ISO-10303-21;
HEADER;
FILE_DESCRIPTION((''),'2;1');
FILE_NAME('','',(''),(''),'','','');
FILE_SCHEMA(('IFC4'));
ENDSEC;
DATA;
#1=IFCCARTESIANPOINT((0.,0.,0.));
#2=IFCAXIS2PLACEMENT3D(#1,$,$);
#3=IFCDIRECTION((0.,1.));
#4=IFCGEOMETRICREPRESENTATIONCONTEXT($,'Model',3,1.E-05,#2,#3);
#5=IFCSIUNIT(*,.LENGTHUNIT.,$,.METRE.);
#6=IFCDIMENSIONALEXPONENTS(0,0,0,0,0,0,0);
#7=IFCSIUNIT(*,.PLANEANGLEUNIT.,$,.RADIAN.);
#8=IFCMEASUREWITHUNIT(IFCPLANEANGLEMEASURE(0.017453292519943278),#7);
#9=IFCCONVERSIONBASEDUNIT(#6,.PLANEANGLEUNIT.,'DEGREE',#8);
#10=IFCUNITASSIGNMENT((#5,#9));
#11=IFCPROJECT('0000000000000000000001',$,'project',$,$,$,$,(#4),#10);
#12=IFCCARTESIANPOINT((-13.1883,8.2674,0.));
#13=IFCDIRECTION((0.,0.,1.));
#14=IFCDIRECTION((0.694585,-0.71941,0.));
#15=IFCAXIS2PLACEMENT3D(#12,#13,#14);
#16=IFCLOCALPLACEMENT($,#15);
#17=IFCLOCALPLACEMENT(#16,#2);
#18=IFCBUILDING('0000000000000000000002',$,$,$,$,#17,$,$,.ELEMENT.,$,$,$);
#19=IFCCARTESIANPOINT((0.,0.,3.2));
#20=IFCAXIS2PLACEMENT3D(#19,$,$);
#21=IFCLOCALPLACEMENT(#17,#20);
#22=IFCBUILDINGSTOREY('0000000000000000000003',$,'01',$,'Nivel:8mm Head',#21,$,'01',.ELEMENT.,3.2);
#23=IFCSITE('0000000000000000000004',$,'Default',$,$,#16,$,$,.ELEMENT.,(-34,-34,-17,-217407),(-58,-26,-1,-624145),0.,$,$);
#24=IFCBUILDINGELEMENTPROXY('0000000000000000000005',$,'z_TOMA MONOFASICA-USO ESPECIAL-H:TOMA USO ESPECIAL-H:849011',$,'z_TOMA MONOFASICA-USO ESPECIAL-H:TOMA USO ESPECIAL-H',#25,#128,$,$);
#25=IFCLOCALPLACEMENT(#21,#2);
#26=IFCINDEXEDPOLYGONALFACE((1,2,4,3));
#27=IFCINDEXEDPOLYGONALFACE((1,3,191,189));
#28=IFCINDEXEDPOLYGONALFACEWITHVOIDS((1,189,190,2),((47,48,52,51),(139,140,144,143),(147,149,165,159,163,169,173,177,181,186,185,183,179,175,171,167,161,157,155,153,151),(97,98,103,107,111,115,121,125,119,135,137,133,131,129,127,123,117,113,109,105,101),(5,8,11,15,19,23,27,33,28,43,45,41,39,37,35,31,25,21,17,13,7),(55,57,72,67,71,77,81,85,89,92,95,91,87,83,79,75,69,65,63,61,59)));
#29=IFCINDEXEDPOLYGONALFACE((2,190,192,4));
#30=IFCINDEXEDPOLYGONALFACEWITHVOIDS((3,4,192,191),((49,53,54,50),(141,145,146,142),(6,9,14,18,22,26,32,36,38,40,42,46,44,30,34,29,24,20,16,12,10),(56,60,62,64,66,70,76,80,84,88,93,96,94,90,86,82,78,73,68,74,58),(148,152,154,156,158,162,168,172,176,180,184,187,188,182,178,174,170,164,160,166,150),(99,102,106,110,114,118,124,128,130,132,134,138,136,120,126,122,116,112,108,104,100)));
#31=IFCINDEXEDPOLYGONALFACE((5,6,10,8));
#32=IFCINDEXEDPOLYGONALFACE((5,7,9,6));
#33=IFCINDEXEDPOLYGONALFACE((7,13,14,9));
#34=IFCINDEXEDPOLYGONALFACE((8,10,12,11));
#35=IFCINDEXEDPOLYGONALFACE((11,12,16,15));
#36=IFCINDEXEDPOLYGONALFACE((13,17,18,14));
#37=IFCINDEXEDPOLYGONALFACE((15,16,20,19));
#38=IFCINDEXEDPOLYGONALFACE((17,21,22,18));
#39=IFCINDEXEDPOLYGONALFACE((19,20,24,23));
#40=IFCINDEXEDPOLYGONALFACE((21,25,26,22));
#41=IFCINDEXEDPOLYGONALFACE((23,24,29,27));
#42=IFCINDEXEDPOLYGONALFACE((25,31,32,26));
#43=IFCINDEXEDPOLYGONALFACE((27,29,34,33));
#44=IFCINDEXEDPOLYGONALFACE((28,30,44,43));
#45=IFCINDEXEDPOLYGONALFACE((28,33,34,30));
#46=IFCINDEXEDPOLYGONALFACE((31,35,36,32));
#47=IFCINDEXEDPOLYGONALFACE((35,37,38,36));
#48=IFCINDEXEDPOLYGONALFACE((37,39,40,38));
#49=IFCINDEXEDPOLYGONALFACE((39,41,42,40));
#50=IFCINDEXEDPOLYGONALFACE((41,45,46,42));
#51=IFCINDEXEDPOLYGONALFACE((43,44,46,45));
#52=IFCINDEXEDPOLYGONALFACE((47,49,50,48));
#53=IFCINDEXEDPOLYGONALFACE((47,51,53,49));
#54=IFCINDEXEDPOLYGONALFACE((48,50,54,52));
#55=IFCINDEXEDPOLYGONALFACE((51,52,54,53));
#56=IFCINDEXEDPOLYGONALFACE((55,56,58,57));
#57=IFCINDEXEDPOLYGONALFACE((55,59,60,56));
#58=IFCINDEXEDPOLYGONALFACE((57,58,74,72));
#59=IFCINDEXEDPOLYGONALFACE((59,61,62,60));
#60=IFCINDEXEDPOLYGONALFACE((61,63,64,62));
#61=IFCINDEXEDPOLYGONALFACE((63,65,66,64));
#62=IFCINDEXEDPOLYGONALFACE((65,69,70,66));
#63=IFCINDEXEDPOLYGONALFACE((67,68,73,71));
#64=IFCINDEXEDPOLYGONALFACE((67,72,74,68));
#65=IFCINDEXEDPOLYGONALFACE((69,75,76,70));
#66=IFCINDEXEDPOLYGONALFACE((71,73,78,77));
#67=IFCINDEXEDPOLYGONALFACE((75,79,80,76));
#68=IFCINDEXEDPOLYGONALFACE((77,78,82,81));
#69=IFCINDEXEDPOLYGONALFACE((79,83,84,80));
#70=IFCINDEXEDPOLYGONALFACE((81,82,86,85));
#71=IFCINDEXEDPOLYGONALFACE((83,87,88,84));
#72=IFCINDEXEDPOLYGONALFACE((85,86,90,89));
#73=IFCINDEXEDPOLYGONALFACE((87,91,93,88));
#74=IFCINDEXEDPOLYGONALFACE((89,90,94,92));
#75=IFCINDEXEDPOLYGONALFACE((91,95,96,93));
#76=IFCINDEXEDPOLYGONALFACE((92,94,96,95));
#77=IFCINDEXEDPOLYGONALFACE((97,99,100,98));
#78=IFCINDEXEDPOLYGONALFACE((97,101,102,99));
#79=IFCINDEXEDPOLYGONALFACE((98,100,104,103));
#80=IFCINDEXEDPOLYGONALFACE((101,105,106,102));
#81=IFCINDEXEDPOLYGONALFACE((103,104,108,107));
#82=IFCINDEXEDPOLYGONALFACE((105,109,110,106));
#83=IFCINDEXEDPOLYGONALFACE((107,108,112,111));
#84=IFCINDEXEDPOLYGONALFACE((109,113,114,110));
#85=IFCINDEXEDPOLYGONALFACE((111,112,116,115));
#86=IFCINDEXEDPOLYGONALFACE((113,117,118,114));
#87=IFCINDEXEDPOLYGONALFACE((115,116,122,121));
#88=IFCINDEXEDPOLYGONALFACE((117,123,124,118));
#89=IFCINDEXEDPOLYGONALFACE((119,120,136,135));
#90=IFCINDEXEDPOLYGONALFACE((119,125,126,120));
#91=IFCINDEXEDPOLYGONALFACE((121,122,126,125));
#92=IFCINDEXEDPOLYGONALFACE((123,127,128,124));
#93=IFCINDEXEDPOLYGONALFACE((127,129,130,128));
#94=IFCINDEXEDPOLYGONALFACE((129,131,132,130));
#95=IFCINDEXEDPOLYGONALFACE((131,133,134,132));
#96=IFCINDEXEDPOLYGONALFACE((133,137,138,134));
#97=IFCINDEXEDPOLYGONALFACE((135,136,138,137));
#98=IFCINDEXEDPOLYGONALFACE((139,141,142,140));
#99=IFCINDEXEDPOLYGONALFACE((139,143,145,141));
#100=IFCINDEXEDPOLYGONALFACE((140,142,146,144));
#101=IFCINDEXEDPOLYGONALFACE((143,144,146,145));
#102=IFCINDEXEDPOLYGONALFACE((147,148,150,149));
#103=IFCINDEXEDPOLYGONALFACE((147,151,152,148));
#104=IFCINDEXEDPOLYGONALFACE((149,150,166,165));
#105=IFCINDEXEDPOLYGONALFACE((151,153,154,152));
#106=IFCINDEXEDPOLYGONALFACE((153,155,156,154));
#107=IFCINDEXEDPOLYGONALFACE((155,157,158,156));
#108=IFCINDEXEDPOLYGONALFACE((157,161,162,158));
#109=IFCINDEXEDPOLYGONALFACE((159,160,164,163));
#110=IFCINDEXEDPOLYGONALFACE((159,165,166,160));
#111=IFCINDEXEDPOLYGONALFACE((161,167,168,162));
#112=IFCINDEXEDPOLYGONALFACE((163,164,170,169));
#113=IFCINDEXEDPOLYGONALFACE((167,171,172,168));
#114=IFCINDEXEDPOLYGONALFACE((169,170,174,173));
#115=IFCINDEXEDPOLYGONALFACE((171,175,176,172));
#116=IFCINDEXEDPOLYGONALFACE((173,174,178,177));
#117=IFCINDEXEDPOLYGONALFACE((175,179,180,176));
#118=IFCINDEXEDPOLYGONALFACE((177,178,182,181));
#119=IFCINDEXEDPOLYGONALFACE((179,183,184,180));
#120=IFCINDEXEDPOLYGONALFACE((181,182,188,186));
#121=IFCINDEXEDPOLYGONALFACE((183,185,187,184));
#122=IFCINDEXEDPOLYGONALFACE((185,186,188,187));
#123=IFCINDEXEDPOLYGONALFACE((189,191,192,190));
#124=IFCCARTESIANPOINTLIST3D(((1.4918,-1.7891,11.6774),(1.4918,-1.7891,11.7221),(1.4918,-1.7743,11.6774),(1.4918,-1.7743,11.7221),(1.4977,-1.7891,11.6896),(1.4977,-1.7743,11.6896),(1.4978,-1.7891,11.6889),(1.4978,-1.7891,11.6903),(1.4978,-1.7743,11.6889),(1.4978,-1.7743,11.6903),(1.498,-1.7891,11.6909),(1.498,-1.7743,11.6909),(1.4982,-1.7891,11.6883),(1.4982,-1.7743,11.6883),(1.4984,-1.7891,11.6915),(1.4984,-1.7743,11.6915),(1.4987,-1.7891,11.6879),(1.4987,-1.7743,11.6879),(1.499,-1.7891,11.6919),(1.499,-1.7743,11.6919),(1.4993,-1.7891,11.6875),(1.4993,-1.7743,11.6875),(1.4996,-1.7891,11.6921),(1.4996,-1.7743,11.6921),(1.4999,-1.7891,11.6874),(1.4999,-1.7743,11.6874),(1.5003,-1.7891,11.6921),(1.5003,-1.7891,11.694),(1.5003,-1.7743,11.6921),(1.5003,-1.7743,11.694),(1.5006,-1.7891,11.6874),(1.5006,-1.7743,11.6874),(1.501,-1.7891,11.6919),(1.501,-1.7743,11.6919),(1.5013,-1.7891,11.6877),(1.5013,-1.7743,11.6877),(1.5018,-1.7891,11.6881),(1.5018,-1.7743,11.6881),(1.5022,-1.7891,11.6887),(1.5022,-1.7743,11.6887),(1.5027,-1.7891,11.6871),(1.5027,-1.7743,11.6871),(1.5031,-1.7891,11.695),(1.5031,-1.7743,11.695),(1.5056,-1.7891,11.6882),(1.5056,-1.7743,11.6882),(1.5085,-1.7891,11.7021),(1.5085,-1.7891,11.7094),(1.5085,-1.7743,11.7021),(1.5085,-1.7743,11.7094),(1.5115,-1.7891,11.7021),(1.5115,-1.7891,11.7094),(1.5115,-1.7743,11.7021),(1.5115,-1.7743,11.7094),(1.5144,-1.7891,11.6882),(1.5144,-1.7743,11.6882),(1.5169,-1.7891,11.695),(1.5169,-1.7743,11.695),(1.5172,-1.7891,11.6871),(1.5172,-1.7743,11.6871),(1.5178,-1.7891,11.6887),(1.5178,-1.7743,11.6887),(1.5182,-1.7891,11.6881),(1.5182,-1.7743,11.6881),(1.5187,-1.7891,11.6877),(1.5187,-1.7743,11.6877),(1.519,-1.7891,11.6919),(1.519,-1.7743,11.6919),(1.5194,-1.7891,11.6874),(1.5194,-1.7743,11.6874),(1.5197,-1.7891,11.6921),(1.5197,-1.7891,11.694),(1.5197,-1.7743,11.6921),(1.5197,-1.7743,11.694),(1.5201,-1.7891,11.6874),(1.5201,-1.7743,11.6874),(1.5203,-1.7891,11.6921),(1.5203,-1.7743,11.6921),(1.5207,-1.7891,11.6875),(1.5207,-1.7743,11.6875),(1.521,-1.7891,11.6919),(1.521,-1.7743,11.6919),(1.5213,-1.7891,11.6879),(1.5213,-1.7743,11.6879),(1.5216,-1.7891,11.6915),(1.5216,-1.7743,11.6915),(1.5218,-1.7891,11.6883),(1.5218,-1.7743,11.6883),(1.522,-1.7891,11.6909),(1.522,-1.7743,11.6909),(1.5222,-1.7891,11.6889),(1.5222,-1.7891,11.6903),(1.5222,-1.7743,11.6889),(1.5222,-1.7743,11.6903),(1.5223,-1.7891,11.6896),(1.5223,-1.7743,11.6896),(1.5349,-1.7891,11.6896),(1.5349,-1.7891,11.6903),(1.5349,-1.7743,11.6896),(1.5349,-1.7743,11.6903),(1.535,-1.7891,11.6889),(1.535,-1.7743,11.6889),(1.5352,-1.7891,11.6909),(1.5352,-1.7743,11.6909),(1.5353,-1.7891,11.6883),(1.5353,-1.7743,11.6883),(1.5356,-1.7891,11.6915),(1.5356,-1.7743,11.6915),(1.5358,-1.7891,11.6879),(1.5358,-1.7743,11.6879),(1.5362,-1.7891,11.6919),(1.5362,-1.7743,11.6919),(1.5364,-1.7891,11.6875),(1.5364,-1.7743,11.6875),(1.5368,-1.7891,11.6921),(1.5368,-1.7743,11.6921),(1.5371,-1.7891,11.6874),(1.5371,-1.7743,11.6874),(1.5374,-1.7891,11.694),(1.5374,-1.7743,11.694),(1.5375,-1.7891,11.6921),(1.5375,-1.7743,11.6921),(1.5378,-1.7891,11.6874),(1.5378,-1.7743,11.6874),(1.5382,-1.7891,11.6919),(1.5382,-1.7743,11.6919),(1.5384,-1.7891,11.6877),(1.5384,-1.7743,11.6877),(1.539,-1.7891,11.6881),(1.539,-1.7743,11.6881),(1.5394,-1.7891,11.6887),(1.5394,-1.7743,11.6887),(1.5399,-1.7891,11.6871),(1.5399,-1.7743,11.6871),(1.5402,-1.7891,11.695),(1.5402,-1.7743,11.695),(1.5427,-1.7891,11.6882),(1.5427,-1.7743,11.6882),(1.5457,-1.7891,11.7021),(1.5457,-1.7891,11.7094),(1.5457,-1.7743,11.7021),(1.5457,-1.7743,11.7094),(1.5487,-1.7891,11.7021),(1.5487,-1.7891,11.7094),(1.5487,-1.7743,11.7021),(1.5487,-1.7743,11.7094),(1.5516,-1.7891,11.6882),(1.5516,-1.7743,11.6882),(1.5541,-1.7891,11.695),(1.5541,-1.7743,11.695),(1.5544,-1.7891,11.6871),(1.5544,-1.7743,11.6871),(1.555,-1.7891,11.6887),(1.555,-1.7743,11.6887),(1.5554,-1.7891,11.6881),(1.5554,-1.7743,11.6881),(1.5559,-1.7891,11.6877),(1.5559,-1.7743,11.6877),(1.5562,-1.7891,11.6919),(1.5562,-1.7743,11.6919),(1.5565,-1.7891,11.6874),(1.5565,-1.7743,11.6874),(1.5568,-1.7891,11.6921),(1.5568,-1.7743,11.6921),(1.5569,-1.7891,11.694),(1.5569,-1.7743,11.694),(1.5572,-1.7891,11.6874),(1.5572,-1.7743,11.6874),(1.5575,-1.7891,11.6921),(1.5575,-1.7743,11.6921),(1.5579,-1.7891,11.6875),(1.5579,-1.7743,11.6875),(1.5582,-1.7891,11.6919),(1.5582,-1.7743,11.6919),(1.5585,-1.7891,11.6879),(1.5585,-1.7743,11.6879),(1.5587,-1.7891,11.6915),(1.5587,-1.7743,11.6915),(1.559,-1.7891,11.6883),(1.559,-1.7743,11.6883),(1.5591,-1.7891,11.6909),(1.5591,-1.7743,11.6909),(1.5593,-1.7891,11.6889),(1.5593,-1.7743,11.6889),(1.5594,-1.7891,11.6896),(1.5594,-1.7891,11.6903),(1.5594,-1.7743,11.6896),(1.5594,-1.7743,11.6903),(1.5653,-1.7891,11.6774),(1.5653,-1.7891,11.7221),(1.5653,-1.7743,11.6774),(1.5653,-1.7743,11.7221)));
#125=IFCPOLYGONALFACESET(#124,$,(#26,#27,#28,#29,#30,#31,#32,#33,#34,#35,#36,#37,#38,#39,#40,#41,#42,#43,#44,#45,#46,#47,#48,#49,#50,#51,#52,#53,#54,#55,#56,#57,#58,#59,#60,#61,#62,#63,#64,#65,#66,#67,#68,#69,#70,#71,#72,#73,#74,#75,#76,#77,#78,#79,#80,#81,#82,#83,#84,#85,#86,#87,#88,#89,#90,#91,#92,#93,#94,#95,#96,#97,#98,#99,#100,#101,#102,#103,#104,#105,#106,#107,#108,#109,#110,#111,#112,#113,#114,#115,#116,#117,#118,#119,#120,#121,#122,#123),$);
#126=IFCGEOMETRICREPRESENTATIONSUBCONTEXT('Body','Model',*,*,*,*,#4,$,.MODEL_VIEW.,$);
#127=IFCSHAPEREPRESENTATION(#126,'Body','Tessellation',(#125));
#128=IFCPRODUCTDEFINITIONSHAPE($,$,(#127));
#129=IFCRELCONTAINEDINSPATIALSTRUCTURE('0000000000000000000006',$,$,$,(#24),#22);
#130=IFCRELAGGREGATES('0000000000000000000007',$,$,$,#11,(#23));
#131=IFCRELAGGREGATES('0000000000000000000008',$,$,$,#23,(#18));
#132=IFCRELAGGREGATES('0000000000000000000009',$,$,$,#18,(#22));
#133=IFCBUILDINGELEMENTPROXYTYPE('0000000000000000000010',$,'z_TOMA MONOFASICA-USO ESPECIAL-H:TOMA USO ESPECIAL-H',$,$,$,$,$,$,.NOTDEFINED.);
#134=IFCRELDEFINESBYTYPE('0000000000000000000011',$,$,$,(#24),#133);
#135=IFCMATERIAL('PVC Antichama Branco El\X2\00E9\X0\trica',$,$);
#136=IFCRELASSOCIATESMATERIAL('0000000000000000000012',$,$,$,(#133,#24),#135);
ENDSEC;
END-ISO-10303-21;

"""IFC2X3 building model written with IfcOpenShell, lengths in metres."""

from ifc_helpers import new_model, entity, si_unit, converted_unit, direction, frame, frame_2d, origin, place, context, subcontext, project, spatial, polyline, circle_curve, parameter, trimmed, segment, composite_curve, outline, extrude, source, transform, mapped, material, type_object, type_shapes, element, save


model = new_model("IFC2X3")

# Units and contexts
model_context = context("Model", 3, precision=1e-05, world=origin(), true_north=direction((0.0, 1.0)))
body_context = subcontext(model_context, "Body", "Model", "MODEL_VIEW")
ifc_project = project(units=[si_unit("LENGTHUNIT", "METRE"), converted_unit("PLANEANGLEUNIT", "DEGREE", entity("IfcPlaneAngleMeasure", 0.017453292519943278), si_unit("PLANEANGLEUNIT", "RADIAN"), dimensions=[0, 0, 0, 0, 0, 0, 0])], contexts=[model_context])

# Site, building, storey
site_placement = place(None, frame((-13.1883, 8.2674, 0.0), z_axis=(0.0, 0.0, 1.0), x_axis=(0.694585, -0.71941, 0.0)))
site = spatial("IfcSite", under=ifc_project, at=site_placement, Name="Default", CompositionType="ELEMENT", RefLatitude=(-34, -34, -17, -217407), RefLongitude=(-58, -26, -1, -624145), RefElevation=0.0)
building_placement = place(site_placement, origin())
building = spatial("IfcBuilding", under=site, at=building_placement, CompositionType="ELEMENT")
storey_placement = place(building_placement, frame((0.0, 0.0, 3.2)))
storey = spatial("IfcBuildingStorey", under=building, at=storey_placement, Name="01", ObjectType="Nivel:8mm Head", LongName="01", CompositionType="ELEMENT", Elevation=3.2)

# Building element proxy
ifc_material_1 = material(Name="PVC Antichama Branco Elétrica")
building_element_proxy_type_1 = type_object("IfcBuildingElementProxyType", Name="z_TOMA MONOFASICA-USO ESPECIAL-H:TOMA USO ESPECIAL-H", PredefinedType="NOTDEFINED", material=ifc_material_1)
shared_shape_1 = source(origin(), body_context, "Body", "SweptSolid", [
    extrude(outline(polyline([(-0.0368, -0.0223), (0.0368, -0.0223), (0.0368, 0.0223), (-0.0368, 0.0223), (-0.0368, -0.0223)]), holes=[composite_curve([segment(polyline([(0.0141, 0.0115), (0.0116, 0.0047)]), True, "CONTINUOUS"), segment(polyline([(0.0116, 0.0047), (0.0088, 0.0057)]), True, "CONTINUOUS"), segment(polyline([(0.0088, 0.0057), (0.0096, 0.0078)]), True, "CONTINUOUS"), segment(trimmed(circle_curve(frame_2d((0.0087, 0.0099), x_axis=(1.0, 0.0)), 0.0024), [parameter(27.118901)], [parameter(292.881099)], True, "PARAMETER"), False, "CONTINUOUS"), segment(polyline([(0.0108, 0.011), (0.0113, 0.0126)]), True, "CONTINUOUS"), segment(polyline([(0.0113, 0.0126), (0.0141, 0.0115)]), True, "CONTINUOUS")], self_intersect=False), composite_curve([segment(polyline([(0.0255, 0.0047), (0.023, 0.0115)]), True, "CONTINUOUS"), segment(polyline([(0.023, 0.0115), (0.0258, 0.0126)]), True, "CONTINUOUS"), segment(polyline([(0.0258, 0.0126), (0.0264, 0.011)]), True, "CONTINUOUS"), segment(trimmed(circle_curve(frame_2d((0.0285, 0.0099), x_axis=(1.0, 0.0)), 0.0024), [parameter(247.118901)], [parameter(152.881099)], True, "PARAMETER"), False, "CONTINUOUS"), segment(polyline([(0.0276, 0.0078), (0.0283, 0.0057)]), True, "CONTINUOUS"), segment(polyline([(0.0283, 0.0057), (0.0255, 0.0047)]), True, "CONTINUOUS")], self_intersect=False), polyline([(0.0201, -0.0024), (0.0201, -0.0097), (0.0171, -0.0097), (0.0171, -0.0024), (0.0201, -0.0024)]), composite_curve([segment(polyline([(-0.0141, 0.0115), (-0.0113, 0.0126)]), True, "CONTINUOUS"), segment(polyline([(-0.0113, 0.0126), (-0.0108, 0.011)]), True, "CONTINUOUS"), segment(trimmed(circle_curve(frame_2d((-0.0087, 0.0099), x_axis=(1.0, 0.0)), 0.0024), [parameter(247.118901)], [parameter(152.881099)], True, "PARAMETER"), False, "CONTINUOUS"), segment(polyline([(-0.0096, 0.0078), (-0.0088, 0.0057)]), True, "CONTINUOUS"), segment(polyline([(-0.0088, 0.0057), (-0.0116, 0.0047)]), True, "CONTINUOUS"), segment(polyline([(-0.0116, 0.0047), (-0.0141, 0.0115)]), True, "CONTINUOUS")], self_intersect=False), composite_curve([segment(polyline([(-0.0255, 0.0047), (-0.0283, 0.0057)]), True, "CONTINUOUS"), segment(polyline([(-0.0283, 0.0057), (-0.0276, 0.0078)]), True, "CONTINUOUS"), segment(trimmed(circle_curve(frame_2d((-0.0285, 0.0099), x_axis=(1.0, 0.0)), 0.0024), [parameter(27.118901)], [parameter(292.881099)], True, "PARAMETER"), False, "CONTINUOUS"), segment(polyline([(-0.0264, 0.011), (-0.0258, 0.0126)]), True, "CONTINUOUS"), segment(polyline([(-0.0258, 0.0126), (-0.023, 0.0115)]), True, "CONTINUOUS"), segment(polyline([(-0.023, 0.0115), (-0.0255, 0.0047)]), True, "CONTINUOUS")], self_intersect=False), polyline([(-0.0201, -0.0024), (-0.0171, -0.0024), (-0.0171, -0.0097), (-0.0201, -0.0097), (-0.0201, -0.0024)])]), frame((0.0, -0.005, 0.0223), z_axis=(0.0, 1.0, 0.0), x_axis=(1.0, 0.0, 0.0)), (0.0, 0.0, 1.0), 0.0148),
])
type_shapes(building_element_proxy_type_1, [shared_shape_1])
for number, where, z_axis, x_axis, name in (
    (1, (1.5286, -1.7793, 11.6774), (0.0, 0.0, 1.0), (-1.0, 0.0, 0.0), "z_TOMA MONOFASICA-USO ESPECIAL-H:TOMA USO ESPECIAL-H:849011"),
):
    element("IfcBuildingElementProxy", number, at=place(storey_placement, frame(where, z_axis=z_axis, x_axis=x_axis)), inside=storey, type_object=building_element_proxy_type_1, material=ifc_material_1, Name=name, ObjectType="z_TOMA MONOFASICA-USO ESPECIAL-H:TOMA USO ESPECIAL-H", context=body_context, shape_type="MappedRepresentation", body=[
        mapped(shared_shape_1, transform((0.0, 0.0, 0.0), scale=1.0)),
    ])

save(model, "model.ifc")
